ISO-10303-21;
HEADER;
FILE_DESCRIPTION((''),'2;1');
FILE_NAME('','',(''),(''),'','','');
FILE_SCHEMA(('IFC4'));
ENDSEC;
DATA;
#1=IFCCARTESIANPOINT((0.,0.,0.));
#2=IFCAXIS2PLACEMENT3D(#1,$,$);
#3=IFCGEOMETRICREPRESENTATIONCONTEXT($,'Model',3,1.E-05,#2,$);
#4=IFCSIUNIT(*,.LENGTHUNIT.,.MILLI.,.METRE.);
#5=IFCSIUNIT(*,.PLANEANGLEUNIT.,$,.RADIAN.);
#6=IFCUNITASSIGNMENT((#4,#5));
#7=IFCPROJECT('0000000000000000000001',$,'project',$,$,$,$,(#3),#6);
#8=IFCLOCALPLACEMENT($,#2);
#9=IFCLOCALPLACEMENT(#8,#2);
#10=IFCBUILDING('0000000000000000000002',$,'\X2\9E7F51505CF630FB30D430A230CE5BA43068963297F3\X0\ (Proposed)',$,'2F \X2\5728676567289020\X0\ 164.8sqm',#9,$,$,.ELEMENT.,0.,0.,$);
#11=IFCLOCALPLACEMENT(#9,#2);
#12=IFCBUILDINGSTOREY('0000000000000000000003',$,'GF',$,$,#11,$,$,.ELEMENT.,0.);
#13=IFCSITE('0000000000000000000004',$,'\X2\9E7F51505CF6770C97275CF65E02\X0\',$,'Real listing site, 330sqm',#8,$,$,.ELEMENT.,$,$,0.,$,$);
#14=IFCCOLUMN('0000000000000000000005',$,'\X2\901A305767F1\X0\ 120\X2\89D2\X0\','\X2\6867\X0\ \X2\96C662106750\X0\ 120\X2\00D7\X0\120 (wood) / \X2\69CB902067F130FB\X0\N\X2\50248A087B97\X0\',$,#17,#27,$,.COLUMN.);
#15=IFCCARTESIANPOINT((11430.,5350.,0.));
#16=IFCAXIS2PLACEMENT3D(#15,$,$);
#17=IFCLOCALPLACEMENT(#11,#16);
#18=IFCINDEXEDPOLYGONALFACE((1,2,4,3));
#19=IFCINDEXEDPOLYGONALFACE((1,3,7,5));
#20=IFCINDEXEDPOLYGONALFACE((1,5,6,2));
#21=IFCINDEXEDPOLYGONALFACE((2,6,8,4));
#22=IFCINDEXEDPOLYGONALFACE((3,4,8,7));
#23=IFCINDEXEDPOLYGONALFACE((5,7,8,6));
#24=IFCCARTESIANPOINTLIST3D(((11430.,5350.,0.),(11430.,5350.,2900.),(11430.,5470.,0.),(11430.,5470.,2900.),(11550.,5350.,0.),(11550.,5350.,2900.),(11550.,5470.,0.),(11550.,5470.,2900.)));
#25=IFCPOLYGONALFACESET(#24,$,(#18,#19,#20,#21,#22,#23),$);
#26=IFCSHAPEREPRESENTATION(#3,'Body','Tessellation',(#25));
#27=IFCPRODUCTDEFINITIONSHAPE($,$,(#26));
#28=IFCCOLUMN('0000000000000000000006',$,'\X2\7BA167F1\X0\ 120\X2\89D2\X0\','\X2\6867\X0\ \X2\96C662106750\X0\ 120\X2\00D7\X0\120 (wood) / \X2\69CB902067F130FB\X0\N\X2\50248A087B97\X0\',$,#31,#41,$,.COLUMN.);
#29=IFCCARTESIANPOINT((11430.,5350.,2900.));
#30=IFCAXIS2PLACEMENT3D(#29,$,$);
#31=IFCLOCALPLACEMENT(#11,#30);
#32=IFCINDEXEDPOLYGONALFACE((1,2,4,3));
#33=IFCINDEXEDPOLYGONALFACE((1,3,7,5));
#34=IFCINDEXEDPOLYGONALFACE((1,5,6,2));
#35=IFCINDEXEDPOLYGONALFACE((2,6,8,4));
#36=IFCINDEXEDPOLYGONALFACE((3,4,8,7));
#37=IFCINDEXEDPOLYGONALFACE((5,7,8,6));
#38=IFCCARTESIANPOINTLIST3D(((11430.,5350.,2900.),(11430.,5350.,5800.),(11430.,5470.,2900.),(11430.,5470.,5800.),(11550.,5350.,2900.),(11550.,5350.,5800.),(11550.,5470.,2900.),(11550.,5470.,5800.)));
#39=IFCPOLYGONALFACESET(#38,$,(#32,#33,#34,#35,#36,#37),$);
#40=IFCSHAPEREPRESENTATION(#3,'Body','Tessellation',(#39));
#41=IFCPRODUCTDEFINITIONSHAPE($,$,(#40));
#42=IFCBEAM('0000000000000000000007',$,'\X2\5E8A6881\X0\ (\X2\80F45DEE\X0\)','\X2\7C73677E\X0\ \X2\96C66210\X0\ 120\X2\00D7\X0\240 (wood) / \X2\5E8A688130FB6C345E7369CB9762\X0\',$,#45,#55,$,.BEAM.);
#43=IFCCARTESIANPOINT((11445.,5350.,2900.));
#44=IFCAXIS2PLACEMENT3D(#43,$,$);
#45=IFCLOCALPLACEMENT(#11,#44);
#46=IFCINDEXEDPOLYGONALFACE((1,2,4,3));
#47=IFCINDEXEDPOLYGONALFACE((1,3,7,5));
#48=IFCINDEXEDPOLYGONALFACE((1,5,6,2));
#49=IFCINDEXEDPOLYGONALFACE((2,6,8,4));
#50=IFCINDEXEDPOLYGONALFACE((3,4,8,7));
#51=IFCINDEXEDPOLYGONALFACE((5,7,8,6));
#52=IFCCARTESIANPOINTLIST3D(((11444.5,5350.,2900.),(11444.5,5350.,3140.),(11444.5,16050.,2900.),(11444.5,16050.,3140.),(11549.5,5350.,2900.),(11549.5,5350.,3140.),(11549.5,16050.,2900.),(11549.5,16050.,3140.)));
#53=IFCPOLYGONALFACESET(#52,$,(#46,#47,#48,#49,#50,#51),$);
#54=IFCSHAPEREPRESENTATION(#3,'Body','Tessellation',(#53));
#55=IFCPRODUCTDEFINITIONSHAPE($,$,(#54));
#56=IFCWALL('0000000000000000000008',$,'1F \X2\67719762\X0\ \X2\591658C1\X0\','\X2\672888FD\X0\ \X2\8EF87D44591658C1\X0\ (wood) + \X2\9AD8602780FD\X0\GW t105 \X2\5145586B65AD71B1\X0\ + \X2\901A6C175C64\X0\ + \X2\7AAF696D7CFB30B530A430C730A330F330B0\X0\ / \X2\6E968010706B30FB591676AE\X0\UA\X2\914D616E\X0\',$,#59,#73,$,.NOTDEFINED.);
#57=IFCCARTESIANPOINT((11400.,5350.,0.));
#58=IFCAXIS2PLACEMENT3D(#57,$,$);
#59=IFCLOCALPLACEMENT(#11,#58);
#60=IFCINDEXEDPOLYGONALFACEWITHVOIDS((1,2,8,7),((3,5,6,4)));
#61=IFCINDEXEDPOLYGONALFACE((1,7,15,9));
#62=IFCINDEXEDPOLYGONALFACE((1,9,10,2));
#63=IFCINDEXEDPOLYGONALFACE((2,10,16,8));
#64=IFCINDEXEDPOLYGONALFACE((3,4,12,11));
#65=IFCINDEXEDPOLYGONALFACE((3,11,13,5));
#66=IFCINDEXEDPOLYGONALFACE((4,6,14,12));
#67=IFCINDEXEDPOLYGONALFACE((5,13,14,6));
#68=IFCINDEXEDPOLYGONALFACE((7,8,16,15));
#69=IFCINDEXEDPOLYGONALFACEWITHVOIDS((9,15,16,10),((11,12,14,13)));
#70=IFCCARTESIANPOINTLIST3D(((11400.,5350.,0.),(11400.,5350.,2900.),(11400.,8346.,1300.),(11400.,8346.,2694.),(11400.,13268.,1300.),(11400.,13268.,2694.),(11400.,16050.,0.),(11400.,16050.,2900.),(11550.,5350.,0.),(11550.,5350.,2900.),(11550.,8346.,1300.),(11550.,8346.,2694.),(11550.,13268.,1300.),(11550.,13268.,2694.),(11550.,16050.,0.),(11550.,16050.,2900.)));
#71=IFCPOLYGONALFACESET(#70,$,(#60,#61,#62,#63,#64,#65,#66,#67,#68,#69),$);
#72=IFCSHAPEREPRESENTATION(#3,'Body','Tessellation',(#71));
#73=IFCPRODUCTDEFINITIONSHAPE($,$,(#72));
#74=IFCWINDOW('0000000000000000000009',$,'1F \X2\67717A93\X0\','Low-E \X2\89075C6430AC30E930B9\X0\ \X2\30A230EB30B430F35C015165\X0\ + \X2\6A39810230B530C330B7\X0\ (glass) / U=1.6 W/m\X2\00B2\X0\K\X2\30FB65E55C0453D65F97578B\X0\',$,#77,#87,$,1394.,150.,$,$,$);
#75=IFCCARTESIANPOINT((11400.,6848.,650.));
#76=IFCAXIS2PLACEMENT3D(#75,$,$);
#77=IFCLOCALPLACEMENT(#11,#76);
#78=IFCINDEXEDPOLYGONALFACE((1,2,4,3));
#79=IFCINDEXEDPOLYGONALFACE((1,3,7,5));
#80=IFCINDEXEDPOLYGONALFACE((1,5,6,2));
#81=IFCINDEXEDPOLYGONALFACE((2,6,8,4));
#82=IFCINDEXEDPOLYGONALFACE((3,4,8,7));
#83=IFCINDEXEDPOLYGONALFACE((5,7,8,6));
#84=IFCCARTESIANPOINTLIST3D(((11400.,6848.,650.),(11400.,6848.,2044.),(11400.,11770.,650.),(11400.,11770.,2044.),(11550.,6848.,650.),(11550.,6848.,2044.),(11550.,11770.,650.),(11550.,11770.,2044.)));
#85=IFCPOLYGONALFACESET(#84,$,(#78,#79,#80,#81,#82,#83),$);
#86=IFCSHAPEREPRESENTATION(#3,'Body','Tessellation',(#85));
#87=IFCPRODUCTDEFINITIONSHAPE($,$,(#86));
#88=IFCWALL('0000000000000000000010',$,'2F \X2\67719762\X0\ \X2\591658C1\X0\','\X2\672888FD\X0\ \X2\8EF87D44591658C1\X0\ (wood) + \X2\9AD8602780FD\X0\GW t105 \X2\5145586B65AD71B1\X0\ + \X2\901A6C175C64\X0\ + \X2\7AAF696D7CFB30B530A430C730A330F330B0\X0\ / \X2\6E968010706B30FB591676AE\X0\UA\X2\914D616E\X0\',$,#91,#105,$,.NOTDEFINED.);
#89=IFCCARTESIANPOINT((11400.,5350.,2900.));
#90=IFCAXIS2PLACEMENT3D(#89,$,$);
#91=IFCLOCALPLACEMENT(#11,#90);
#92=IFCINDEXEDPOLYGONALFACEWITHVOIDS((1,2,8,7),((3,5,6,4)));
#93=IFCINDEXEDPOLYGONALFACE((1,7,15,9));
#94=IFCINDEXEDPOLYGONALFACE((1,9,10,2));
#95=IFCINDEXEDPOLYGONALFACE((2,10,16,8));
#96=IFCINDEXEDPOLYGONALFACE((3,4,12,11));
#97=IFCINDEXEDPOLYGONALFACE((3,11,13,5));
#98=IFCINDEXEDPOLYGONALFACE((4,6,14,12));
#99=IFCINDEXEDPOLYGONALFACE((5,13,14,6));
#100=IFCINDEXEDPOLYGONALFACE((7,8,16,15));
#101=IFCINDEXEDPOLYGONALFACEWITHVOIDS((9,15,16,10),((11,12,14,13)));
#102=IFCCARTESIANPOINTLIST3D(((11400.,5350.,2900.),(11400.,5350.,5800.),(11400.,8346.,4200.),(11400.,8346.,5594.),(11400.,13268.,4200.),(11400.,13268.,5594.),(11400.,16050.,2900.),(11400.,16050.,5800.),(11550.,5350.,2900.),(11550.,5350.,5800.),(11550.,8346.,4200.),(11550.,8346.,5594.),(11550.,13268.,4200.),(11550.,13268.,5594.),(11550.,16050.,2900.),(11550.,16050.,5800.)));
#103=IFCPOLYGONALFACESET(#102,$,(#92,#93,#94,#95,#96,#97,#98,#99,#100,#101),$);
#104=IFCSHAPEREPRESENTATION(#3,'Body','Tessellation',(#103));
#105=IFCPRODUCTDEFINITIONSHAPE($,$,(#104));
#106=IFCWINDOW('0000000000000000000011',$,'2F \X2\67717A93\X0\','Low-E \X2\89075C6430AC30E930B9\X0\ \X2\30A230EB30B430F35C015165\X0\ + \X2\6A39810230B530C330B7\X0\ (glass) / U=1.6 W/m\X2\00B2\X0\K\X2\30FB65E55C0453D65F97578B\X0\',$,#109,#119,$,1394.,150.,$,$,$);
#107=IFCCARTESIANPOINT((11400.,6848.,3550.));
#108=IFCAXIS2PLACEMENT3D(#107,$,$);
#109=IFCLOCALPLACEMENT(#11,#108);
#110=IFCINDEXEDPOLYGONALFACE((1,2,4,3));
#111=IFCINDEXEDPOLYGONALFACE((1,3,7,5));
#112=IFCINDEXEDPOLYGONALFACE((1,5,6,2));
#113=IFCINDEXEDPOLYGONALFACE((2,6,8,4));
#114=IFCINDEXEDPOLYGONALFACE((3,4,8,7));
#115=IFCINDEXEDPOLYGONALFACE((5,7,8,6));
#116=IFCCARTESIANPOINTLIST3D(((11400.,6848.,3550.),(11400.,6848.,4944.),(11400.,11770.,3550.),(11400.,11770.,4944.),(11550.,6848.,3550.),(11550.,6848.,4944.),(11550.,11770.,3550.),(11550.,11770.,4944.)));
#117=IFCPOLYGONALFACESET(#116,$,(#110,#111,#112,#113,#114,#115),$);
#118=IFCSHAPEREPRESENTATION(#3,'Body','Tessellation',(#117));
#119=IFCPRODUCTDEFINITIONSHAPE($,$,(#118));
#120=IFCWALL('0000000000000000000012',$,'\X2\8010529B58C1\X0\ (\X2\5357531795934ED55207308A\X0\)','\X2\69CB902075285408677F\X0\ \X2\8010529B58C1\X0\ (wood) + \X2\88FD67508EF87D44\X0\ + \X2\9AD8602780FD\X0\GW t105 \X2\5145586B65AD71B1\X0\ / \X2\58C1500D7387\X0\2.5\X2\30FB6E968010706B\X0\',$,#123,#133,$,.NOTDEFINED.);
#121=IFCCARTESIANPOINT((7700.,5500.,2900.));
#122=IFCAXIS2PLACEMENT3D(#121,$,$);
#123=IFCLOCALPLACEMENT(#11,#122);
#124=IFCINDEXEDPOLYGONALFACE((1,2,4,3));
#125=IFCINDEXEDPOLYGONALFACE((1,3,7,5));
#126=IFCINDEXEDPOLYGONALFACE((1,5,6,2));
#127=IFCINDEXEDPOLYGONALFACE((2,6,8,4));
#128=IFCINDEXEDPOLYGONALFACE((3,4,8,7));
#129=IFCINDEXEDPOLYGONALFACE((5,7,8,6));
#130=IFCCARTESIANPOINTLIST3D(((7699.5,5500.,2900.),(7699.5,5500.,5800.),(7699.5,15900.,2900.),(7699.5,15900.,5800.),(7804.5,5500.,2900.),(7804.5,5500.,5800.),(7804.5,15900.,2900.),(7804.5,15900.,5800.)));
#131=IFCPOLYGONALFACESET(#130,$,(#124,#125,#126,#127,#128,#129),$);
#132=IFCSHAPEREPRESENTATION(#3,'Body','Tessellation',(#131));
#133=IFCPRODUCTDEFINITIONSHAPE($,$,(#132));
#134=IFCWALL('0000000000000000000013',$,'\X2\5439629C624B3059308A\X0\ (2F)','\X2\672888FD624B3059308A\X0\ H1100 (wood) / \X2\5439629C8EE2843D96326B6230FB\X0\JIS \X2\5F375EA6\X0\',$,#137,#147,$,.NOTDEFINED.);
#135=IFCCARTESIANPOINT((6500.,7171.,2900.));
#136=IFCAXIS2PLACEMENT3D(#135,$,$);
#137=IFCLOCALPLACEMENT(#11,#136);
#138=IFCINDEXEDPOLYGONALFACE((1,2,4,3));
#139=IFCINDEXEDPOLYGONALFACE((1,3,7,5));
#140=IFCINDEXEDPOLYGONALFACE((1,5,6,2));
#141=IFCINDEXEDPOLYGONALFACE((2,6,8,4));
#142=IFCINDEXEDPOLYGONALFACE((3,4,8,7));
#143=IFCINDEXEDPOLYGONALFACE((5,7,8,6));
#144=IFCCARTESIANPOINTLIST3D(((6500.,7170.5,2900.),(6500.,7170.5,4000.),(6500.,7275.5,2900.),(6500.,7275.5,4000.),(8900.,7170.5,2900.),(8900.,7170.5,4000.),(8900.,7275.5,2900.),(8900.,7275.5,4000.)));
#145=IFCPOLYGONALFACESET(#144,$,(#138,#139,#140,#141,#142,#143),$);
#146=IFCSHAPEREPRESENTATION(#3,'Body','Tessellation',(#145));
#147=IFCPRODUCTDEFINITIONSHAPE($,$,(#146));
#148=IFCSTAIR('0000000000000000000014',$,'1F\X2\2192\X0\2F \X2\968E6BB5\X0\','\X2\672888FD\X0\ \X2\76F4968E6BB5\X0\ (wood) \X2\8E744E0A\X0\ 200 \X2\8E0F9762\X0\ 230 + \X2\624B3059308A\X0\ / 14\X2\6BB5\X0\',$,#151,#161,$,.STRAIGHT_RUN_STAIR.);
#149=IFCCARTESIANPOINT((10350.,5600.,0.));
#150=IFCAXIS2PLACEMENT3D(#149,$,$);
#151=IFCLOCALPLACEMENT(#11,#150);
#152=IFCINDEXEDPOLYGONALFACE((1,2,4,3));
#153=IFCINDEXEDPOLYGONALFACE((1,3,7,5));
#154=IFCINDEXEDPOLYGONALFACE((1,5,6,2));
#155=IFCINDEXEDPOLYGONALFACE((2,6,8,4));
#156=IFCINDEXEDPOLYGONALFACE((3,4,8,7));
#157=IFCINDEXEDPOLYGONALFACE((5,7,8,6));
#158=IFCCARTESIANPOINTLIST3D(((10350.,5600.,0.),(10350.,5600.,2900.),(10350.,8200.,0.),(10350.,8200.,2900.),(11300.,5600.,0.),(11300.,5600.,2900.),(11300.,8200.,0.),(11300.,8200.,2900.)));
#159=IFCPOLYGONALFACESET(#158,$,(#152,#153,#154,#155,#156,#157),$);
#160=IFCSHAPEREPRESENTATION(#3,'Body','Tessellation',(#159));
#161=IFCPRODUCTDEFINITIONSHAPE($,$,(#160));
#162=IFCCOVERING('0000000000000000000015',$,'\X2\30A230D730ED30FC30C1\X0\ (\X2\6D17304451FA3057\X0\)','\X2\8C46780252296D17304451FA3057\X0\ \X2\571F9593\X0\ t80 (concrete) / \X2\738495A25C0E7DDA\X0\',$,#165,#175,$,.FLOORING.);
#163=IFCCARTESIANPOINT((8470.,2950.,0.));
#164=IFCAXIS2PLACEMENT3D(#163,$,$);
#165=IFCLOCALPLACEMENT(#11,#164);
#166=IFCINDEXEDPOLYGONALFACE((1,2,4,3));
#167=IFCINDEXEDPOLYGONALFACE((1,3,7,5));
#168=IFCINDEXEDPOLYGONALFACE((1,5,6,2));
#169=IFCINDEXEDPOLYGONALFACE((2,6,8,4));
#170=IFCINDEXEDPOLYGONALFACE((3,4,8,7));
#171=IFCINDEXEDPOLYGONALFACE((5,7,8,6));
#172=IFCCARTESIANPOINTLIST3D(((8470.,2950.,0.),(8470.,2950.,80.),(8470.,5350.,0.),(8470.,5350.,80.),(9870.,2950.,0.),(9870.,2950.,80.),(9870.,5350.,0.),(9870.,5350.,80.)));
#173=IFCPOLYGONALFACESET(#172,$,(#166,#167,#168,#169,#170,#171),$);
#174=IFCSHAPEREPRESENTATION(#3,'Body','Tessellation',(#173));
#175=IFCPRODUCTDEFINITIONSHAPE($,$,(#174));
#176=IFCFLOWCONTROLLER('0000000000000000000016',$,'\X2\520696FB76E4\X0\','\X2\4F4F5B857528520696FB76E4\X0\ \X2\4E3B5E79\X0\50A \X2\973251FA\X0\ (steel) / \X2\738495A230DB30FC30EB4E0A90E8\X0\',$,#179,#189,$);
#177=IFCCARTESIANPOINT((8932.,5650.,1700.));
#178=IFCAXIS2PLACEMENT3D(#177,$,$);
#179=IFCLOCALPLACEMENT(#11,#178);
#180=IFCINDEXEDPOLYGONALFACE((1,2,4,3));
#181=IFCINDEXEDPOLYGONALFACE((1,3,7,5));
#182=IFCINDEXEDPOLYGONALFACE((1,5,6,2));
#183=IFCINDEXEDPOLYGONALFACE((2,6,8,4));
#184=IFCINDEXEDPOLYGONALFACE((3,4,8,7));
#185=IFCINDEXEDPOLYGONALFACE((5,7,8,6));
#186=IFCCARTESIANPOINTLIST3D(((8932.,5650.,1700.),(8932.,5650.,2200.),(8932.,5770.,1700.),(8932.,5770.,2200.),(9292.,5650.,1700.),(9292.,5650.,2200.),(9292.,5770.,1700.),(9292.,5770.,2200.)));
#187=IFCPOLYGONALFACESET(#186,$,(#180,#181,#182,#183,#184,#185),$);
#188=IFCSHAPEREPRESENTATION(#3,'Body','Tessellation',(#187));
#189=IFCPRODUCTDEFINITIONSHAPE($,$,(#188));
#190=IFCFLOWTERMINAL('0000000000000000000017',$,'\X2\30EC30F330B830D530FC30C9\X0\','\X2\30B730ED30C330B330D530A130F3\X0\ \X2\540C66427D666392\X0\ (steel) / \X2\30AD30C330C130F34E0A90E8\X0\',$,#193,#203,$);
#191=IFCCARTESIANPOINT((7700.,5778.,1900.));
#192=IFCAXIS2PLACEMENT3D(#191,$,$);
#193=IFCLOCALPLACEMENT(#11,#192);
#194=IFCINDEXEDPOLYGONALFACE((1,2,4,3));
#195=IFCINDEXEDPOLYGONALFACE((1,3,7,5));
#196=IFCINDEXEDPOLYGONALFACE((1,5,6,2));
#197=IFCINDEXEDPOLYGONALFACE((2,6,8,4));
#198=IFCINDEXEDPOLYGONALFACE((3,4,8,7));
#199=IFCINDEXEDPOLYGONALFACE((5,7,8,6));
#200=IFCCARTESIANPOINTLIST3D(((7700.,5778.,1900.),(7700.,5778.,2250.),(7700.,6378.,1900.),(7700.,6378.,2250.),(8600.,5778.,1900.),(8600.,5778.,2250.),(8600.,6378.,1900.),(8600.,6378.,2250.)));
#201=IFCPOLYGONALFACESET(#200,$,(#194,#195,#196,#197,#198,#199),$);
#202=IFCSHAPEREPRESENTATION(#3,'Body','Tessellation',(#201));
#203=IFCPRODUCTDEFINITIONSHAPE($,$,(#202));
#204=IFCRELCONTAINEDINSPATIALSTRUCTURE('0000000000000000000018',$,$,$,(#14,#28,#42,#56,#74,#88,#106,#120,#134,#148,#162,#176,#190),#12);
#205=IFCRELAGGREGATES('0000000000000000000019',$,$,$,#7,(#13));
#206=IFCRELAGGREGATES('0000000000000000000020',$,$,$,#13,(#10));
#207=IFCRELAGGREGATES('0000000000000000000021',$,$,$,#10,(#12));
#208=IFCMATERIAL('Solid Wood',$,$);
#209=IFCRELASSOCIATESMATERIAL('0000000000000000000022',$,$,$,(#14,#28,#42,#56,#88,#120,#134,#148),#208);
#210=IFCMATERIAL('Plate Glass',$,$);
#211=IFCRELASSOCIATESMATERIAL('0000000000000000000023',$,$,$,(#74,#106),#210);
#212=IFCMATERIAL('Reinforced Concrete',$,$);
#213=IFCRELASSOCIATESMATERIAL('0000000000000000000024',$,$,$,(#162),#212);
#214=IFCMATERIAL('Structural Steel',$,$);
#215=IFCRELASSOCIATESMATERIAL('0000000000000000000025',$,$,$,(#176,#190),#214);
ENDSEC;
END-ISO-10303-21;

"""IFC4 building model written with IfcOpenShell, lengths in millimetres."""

from ifc_helpers import new_model, si_unit, frame, frame_2d, origin, place, context, project, spatial, rectangle, extrude, material, element, fill, save


model = new_model("IFC4")

# Units and contexts
model_context = context("Model", 3, precision=1e-05, world=origin())
ifc_project = project(units=[si_unit("LENGTHUNIT", "METRE", prefix="MILLI"), si_unit("PLANEANGLEUNIT", "RADIAN")], contexts=[model_context])

# Site, building, storey
site_placement = place(None, origin())
site = spatial("IfcSite", under=ifc_project, at=site_placement, Name="鹿児島県霧島市", ObjectType="Real listing site, 330sqm", CompositionType="ELEMENT", RefElevation=0.0)
building_placement = place(site_placement, origin())
building = spatial("IfcBuilding", under=site, at=building_placement, Name="鹿児島・ピアノ室と防音 (Proposed)", ObjectType="2F 在来木造 164.8sqm", CompositionType="ELEMENT", ElevationOfRefHeight=0.0, ElevationOfTerrain=0.0)
storey_placement = place(building_placement, origin())
storey = spatial("IfcBuildingStorey", under=building, at=storey_placement, Name="GF", CompositionType="ELEMENT", Elevation=0.0)

# Columns
ifc_material_1 = material(Name="Solid Wood")
column_1_placement = place(storey_placement, frame((11430.0, 5350.0, 0.0)))
element("IfcColumn", 1, at=column_1_placement, inside=storey, material=ifc_material_1, Name="通し柱 120角", Description="桧 集成材 120×120 (wood) / 構造柱・N値計算", PredefinedType="COLUMN", context=model_context, shape_type="SweptSolid", body=[
    extrude(rectangle(XDim=120.0, YDim=120.0, at=frame_2d((60.0, 60.0))), frame((11430.0, 5350.0, 0.0)), (0.0, 0.0, 1.0), 2900.0),
])
column_2_placement = place(storey_placement, frame((11430.0, 5350.0, 2900.0)))
element("IfcColumn", 2, at=column_2_placement, inside=storey, material=ifc_material_1, Name="管柱 120角", Description="桧 集成材 120×120 (wood) / 構造柱・N値計算", PredefinedType="COLUMN", context=model_context, shape_type="SweptSolid", body=[
    extrude(rectangle(XDim=120.0, YDim=120.0, at=frame_2d((60.0, 60.0))), frame((11430.0, 5350.0, 2900.0)), (0.0, 0.0, 1.0), 2900.0),
])

# Beam
beam_1_placement = place(storey_placement, frame((11445.0, 5350.0, 2900.0)))
element("IfcBeam", 3, at=beam_1_placement, inside=storey, material=ifc_material_1, Name="床梁 (胴差)", Description="米松 集成 120×240 (wood) / 床梁・水平構面", PredefinedType="BEAM", context=model_context, shape_type="SweptSolid", body=[
    extrude(rectangle(XDim=105.0, YDim=10700.0, at=frame_2d((52.0, 5350.0))), frame((11445.0, 5350.0, 2900.0)), (0.0, 0.0, 1.0), 240.0),
])

# Wall, opening, window
wall_1_placement = place(storey_placement, frame((11400.0, 5350.0, 0.0)))
wall_1 = element("IfcWall", 4, at=wall_1_placement, inside=storey, material=ifc_material_1, Name="1F 東面 外壁", Description="木製 軸組外壁 (wood) + 高性能GW t105 充填断熱 + 通気層 + 窯業系サイディング / 準耐火・外皮UA配慮", PredefinedType="NOTDEFINED", context=model_context, shape_type="SweptSolid", body=[
    extrude(rectangle(XDim=150.0, YDim=10700.0, at=frame_2d((75.0, 5350.0))), frame((11400.0, 5350.0, 0.0)), (0.0, 0.0, 1.0), 2900.0),
])
opening_1_placement = place(storey_placement, frame((11400.0, 6848.0, 650.0)))
opening_1 = element("IfcOpeningElement", 5, at=opening_1_placement, cuts=wall_1, PredefinedType="NOTDEFINED", context=model_context, shape_type="SweptSolid", body=[
    extrude(rectangle(XDim=150.0, YDim=4922.0, at=frame_2d((75.0, 2461.0))), frame((11400.0, 6848.0, 650.0)), (0.0, 0.0, 1.0), 1394.0),
])
ifc_material_2 = material(Name="Plate Glass")
window_1_placement = place(storey_placement, frame((11400.0, 6848.0, 650.0)))
window_1 = element("IfcWindow", 6, at=window_1_placement, inside=storey, material=ifc_material_2, Name="1F 東窓", Description="Low-E 複層ガラス アルゴン封入 + 樹脂サッシ (glass) / U=1.6 W/m²K・日射取得型", OverallHeight=1394.0, OverallWidth=150.0, context=model_context, shape_type="SweptSolid", body=[
    extrude(rectangle(XDim=150.0, YDim=4922.0, at=frame_2d((75.0, 2461.0))), frame((11400.0, 6848.0, 650.0)), (0.0, 0.0, 1.0), 1394.0),
])
fill(opening_1, window_1)

# Wall, opening, window
wall_2_placement = place(storey_placement, frame((11400.0, 5350.0, 2900.0)))
wall_2 = element("IfcWall", 7, at=wall_2_placement, inside=storey, material=ifc_material_1, Name="2F 東面 外壁", Description="木製 軸組外壁 (wood) + 高性能GW t105 充填断熱 + 通気層 + 窯業系サイディング / 準耐火・外皮UA配慮", PredefinedType="NOTDEFINED", context=model_context, shape_type="SweptSolid", body=[
    extrude(rectangle(XDim=150.0, YDim=10700.0, at=frame_2d((75.0, 5350.0))), frame((11400.0, 5350.0, 2900.0)), (0.0, 0.0, 1.0), 2900.0),
])
opening_2_placement = place(storey_placement, frame((11400.0, 6848.0, 3550.0)))
opening_2 = element("IfcOpeningElement", 8, at=opening_2_placement, cuts=wall_2, PredefinedType="NOTDEFINED", context=model_context, shape_type="SweptSolid", body=[
    extrude(rectangle(XDim=150.0, YDim=4922.0, at=frame_2d((75.0, 2461.0))), frame((11400.0, 6848.0, 3550.0)), (0.0, 0.0, 1.0), 1394.0),
])
window_2_placement = place(storey_placement, frame((11400.0, 6848.0, 3550.0)))
window_2 = element("IfcWindow", 9, at=window_2_placement, inside=storey, material=ifc_material_2, Name="2F 東窓", Description="Low-E 複層ガラス アルゴン封入 + 樹脂サッシ (glass) / U=1.6 W/m²K・日射取得型", OverallHeight=1394.0, OverallWidth=150.0, context=model_context, shape_type="SweptSolid", body=[
    extrude(rectangle(XDim=150.0, YDim=4922.0, at=frame_2d((75.0, 2461.0))), frame((11400.0, 6848.0, 3550.0)), (0.0, 0.0, 1.0), 1394.0),
])
fill(opening_2, window_2)

# Walls
wall_3_placement = place(storey_placement, frame((7700.0, 5500.0, 2900.0)))
element("IfcWall", 10, at=wall_3_placement, inside=storey, material=ifc_material_1, Name="耐力壁 (南北間仕切り)", Description="構造用合板 耐力壁 (wood) + 製材軸組 + 高性能GW t105 充填断熱 / 壁倍率2.5・準耐火", PredefinedType="NOTDEFINED", context=model_context, shape_type="SweptSolid", body=[
    extrude(rectangle(XDim=105.0, YDim=10400.0, at=frame_2d((52.0, 5200.0))), frame((7700.0, 5500.0, 2900.0)), (0.0, 0.0, 1.0), 2900.0),
])
wall_4_placement = place(storey_placement, frame((6500.0, 7171.0, 2900.0)))
element("IfcWall", 11, at=wall_4_placement, inside=storey, material=ifc_material_1, Name="吹抜手すり (2F)", Description="木製手すり H1100 (wood) / 吹抜転落防止・JIS 強度", PredefinedType="NOTDEFINED", context=model_context, shape_type="SweptSolid", body=[
    extrude(rectangle(XDim=2400.0, YDim=105.0, at=frame_2d((1200.0, 52.0))), frame((6500.0, 7171.0, 2900.0)), (0.0, 0.0, 1.0), 1100.0),
])

# Stair
stair_placement = place(storey_placement, frame((10350.0, 5600.0, 0.0)))
element("IfcStair", 12, at=stair_placement, inside=storey, material=ifc_material_1, Name="1F→2F 階段", Description="木製 直階段 (wood) 蹴上 200 踏面 230 + 手すり / 14段", PredefinedType="STRAIGHT_RUN_STAIR", context=model_context, shape_type="SweptSolid", body=[
    extrude(rectangle(XDim=950.0, YDim=2600.0, at=frame_2d((475.0, 1300.0))), frame((10350.0, 5600.0, 0.0)), (0.0, 0.0, 1.0), 2900.0),
])

# Covering
ifc_material_3 = material(Name="Reinforced Concrete")
covering_placement = place(storey_placement, frame((8470.0, 2950.0, 0.0)))
element("IfcCovering", 13, at=covering_placement, inside=storey, material=ifc_material_3, Name="アプローチ (洗い出し)", Description="豆砂利洗い出し 土間 t80 (concrete) / 玄関導線", PredefinedType="FLOORING", context=model_context, shape_type="SweptSolid", body=[
    extrude(rectangle(XDim=1400.0, YDim=2400.0, at=frame_2d((700.0, 1200.0))), frame((8470.0, 2950.0, 0.0)), (0.0, 0.0, 1.0), 80.0),
])

# Flow controller
ifc_material_4 = material(Name="Structural Steel")
flow_controller_placement = place(storey_placement, frame((8932.0, 5650.0, 1700.0)))
element("IfcFlowController", 14, at=flow_controller_placement, inside=storey, material=ifc_material_4, Name="分電盤", Description="住宅用分電盤 主幹50A 露出 (steel) / 玄関ホール上部", context=model_context, shape_type="SweptSolid", body=[
    extrude(rectangle(XDim=360.0, YDim=120.0, at=frame_2d((180.0, 60.0))), frame((8932.0, 5650.0, 1700.0)), (0.0, 0.0, 1.0), 500.0),
])

# Flow terminal
flow_terminal_1_placement = place(storey_placement, frame((7700.0, 5778.0, 1900.0)))
element("IfcFlowTerminal", 15, at=flow_terminal_1_placement, inside=storey, material=ifc_material_4, Name="レンジフード", Description="シロッコファン 同時給排 (steel) / キッチン上部", context=model_context, shape_type="SweptSolid", body=[
    extrude(rectangle(XDim=900.0, YDim=600.0, at=frame_2d((450.0, 300.0))), frame((7700.0, 5778.0, 1900.0)), (0.0, 0.0, 1.0), 350.0),
])

save(model, "model.ifc")
